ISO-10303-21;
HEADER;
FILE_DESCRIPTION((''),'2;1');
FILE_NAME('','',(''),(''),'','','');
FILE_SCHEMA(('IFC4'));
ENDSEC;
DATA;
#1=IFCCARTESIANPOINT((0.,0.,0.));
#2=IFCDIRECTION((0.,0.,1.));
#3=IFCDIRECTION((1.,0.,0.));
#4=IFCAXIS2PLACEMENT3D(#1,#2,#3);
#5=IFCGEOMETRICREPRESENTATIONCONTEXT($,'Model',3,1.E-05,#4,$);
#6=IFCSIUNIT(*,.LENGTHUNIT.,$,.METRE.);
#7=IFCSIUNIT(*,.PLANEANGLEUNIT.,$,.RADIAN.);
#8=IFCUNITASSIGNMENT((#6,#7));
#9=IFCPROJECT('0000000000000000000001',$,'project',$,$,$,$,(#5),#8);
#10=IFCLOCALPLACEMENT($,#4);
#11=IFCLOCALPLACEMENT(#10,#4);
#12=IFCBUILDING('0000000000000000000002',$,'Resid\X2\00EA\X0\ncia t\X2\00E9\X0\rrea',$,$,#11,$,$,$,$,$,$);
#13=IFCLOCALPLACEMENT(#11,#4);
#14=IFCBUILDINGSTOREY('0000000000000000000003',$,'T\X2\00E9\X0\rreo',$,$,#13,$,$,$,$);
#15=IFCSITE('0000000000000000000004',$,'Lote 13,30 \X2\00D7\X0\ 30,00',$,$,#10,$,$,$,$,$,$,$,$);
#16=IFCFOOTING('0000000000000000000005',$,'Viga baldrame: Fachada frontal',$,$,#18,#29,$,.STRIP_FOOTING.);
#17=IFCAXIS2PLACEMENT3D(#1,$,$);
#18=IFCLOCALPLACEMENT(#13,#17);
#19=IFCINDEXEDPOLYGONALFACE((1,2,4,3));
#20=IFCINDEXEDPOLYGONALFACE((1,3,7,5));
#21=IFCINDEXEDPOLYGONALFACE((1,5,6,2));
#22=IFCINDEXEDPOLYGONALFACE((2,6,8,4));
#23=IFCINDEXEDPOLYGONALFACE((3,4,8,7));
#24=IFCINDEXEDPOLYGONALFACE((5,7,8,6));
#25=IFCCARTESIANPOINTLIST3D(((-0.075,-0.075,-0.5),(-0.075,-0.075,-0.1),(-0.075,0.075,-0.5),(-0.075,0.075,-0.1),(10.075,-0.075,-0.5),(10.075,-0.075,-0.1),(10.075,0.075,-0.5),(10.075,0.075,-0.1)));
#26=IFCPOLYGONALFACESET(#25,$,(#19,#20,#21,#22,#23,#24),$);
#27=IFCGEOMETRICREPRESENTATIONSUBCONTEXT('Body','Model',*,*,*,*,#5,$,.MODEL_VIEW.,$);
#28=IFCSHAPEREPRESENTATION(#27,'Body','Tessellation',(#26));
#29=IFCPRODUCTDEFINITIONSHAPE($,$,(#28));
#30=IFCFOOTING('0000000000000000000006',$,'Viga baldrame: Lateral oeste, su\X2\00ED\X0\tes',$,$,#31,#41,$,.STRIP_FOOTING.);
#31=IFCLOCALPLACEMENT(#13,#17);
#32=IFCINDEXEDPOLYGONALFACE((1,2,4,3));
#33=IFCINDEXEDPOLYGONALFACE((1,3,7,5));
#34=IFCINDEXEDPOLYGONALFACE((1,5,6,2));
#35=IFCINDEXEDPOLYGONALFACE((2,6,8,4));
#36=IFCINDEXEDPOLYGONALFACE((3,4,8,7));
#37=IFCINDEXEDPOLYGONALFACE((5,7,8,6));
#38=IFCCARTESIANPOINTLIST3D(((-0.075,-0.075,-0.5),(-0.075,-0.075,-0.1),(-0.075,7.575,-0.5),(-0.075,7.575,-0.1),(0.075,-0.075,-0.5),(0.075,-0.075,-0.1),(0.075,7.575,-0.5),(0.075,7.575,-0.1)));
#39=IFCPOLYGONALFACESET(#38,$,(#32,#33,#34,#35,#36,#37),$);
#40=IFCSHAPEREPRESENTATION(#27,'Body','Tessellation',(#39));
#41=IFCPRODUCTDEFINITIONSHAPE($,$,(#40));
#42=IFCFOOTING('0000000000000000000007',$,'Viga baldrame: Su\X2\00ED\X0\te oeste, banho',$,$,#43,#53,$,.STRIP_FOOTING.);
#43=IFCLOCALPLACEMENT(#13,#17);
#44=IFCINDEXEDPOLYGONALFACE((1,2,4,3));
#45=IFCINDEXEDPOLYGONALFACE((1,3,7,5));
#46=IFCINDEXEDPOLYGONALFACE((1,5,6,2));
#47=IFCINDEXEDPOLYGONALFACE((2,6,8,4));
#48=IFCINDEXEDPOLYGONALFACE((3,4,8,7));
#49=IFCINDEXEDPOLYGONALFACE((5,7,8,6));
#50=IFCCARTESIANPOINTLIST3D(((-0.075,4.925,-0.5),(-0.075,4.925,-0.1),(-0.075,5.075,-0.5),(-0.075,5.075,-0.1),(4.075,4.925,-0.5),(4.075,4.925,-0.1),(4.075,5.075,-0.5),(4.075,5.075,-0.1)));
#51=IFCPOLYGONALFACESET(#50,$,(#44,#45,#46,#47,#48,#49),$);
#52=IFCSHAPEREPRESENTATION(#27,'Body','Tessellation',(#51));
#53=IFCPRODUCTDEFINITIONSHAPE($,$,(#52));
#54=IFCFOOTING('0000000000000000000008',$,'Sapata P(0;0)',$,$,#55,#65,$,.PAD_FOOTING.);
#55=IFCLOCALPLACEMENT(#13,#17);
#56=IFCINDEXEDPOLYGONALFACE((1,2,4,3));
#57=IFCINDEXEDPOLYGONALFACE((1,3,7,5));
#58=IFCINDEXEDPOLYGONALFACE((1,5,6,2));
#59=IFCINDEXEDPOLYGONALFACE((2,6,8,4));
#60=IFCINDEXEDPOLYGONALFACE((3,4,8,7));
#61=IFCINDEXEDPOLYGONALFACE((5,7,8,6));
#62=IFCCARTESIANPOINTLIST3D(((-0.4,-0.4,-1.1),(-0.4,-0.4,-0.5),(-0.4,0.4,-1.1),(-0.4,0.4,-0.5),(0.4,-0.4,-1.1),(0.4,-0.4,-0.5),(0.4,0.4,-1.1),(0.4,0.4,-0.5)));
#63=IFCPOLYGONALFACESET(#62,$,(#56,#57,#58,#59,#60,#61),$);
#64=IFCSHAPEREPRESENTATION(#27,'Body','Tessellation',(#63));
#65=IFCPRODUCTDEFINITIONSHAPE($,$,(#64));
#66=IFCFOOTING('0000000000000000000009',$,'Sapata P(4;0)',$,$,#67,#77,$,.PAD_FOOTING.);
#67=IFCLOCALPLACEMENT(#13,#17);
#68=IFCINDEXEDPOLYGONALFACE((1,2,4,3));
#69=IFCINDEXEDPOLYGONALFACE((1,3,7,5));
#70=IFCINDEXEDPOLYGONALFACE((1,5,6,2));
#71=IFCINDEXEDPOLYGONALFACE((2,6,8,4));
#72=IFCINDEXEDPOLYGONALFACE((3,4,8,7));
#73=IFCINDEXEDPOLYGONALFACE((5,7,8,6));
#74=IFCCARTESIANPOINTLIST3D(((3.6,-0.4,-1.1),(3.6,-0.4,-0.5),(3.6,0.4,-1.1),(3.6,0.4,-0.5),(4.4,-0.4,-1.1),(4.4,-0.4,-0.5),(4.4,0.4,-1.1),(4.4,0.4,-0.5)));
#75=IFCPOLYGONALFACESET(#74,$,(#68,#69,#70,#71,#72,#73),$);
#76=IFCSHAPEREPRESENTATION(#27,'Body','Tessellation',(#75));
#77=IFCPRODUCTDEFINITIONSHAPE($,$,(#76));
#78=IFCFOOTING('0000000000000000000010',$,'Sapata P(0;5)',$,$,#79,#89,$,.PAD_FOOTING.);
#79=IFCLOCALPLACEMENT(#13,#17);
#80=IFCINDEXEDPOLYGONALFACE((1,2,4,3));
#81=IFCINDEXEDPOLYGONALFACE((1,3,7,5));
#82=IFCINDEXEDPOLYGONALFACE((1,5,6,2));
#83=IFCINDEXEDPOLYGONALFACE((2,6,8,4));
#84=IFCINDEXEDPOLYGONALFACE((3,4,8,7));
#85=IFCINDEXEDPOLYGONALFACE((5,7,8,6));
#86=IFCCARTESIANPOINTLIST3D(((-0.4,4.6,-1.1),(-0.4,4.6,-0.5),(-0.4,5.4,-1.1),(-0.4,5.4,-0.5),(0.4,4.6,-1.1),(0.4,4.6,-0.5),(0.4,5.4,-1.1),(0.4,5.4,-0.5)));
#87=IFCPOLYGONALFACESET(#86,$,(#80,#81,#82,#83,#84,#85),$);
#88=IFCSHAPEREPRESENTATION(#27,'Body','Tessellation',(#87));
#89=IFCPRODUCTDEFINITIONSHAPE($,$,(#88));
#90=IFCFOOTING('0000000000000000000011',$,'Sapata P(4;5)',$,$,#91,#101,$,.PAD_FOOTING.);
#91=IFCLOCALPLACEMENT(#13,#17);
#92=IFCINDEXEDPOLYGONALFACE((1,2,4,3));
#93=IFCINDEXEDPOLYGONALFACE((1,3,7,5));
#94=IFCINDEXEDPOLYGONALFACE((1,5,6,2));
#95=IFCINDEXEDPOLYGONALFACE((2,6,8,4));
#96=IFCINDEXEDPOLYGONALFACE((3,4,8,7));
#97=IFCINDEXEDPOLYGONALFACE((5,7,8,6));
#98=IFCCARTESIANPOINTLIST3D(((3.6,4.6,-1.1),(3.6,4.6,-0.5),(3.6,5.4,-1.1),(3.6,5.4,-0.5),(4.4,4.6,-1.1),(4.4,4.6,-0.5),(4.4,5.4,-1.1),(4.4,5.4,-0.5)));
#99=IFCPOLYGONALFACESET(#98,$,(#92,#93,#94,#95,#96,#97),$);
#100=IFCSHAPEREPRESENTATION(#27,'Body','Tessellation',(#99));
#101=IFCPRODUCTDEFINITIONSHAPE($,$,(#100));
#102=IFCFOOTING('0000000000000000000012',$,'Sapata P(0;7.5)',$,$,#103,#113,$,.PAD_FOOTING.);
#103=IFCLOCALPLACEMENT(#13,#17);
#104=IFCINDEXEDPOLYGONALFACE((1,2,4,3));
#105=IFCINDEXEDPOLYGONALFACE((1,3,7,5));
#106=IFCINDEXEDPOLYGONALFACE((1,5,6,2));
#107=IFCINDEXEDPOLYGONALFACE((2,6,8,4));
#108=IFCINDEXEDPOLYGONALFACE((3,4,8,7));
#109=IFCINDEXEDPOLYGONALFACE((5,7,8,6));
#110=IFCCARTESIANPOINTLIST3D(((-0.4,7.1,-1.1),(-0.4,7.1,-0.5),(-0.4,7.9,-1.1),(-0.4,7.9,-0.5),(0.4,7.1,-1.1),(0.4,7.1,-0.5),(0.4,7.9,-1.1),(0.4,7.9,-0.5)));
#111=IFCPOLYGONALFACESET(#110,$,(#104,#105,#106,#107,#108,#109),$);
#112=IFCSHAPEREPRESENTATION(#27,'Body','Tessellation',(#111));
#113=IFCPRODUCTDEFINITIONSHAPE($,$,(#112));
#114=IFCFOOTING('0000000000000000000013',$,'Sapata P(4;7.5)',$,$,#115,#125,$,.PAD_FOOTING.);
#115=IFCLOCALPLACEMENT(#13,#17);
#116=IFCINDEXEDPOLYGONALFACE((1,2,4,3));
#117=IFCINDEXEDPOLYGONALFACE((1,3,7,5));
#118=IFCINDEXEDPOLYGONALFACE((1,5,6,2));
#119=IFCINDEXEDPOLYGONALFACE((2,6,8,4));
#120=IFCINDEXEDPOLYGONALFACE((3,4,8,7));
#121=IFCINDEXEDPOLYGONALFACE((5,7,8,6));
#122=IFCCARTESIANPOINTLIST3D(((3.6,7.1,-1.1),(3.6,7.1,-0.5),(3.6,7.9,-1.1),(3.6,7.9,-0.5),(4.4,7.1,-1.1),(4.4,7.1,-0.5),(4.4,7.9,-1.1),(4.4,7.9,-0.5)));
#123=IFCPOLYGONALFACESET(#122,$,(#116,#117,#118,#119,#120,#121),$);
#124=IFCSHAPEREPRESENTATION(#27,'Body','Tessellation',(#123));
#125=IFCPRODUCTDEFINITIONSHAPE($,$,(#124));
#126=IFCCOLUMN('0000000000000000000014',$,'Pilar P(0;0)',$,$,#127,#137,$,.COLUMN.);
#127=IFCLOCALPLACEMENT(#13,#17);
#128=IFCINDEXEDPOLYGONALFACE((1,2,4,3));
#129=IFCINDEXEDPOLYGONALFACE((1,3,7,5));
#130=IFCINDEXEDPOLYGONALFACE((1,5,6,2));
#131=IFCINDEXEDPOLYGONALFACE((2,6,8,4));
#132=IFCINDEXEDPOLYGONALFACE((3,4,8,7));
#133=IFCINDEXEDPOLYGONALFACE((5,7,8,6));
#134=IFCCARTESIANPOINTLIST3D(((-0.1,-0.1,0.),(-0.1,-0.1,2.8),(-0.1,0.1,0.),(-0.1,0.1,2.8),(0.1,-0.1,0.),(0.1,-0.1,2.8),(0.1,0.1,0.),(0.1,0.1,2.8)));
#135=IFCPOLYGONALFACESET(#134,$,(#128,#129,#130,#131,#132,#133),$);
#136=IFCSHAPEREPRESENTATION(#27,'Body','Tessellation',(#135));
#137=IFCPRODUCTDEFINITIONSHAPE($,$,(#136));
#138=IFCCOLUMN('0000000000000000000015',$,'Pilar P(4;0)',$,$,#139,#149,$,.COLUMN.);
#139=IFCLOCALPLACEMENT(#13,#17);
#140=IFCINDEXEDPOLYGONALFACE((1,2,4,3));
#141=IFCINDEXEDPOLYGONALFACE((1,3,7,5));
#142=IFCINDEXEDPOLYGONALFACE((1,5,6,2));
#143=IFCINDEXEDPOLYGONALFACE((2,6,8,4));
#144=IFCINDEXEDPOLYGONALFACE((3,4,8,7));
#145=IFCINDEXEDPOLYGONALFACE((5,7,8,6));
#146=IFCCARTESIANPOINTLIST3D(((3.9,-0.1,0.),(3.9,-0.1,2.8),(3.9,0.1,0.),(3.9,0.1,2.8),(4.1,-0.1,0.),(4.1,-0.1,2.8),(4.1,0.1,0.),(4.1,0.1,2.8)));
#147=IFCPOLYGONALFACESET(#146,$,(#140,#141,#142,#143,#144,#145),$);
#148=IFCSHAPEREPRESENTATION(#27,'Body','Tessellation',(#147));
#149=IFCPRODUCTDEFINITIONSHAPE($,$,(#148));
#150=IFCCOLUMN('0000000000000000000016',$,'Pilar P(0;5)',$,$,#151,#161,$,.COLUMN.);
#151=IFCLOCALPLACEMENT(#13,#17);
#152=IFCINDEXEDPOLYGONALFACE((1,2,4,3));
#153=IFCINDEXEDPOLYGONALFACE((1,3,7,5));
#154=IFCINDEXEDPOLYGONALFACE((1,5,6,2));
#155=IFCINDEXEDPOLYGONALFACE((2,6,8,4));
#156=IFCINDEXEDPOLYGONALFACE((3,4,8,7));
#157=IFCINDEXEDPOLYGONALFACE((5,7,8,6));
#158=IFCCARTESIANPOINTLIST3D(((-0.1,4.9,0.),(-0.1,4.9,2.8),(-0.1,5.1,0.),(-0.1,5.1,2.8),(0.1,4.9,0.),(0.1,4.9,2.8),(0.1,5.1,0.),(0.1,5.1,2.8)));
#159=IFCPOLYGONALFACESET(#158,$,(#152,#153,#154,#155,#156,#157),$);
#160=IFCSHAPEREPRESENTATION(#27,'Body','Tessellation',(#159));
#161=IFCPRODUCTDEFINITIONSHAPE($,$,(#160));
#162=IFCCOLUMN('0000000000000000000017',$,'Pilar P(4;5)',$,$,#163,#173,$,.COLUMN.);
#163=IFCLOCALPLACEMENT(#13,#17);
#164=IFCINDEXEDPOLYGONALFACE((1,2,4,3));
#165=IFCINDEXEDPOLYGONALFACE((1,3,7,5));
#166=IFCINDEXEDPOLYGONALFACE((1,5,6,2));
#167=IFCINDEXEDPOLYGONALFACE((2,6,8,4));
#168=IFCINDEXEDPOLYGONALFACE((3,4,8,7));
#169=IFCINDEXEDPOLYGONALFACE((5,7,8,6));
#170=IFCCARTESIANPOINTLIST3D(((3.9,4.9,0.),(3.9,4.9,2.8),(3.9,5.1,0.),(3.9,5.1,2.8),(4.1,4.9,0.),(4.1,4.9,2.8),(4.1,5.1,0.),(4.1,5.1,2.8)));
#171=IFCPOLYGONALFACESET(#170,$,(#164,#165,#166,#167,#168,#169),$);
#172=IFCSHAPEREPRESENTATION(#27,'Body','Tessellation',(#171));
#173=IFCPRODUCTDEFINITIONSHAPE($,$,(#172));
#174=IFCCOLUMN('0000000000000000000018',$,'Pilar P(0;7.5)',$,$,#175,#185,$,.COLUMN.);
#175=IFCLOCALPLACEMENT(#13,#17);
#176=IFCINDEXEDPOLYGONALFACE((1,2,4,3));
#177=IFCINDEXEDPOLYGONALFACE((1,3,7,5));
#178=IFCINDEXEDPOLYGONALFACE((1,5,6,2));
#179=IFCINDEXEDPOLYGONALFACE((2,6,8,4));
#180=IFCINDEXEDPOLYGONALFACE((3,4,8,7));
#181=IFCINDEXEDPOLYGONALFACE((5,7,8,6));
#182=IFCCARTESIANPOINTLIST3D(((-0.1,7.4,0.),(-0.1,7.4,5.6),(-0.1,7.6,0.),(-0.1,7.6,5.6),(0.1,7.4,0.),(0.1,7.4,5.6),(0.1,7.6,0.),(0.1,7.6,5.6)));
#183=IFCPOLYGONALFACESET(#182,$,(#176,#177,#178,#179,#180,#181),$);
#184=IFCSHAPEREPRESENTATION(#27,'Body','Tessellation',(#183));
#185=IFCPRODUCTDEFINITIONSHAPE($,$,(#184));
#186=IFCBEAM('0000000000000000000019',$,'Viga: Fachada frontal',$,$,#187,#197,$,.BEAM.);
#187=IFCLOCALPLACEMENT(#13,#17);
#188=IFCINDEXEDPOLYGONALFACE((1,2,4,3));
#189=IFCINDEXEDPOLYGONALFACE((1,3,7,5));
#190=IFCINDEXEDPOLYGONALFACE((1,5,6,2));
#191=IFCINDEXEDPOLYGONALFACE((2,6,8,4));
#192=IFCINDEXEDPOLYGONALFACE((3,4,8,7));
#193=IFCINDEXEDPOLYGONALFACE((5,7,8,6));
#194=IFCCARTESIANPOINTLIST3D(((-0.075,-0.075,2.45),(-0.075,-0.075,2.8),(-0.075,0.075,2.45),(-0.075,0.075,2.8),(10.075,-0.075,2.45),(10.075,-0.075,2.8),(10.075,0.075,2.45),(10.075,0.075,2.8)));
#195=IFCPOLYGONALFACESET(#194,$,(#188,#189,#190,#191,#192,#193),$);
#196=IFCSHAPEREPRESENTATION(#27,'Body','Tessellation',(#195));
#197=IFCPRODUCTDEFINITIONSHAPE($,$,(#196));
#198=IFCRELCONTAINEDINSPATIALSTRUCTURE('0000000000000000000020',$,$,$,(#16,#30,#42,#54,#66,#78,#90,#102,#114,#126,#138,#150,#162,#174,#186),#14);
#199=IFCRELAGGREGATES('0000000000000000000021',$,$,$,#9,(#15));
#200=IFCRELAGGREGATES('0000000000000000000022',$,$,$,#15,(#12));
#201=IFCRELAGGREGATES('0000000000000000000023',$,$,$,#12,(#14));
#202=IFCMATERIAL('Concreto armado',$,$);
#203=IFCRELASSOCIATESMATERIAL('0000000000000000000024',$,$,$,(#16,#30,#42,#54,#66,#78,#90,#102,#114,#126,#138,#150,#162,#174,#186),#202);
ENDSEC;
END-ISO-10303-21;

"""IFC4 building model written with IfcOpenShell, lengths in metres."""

from ifc_helpers import new_model, si_unit, frame, origin_with_axes, place, context, subcontext, project, spatial, line, indexed_curve, outline, extrude, material, element, save


model = new_model("IFC4")

# Units and contexts
model_context = context("Model", 3, precision=1e-05, world=origin_with_axes())
body_context = subcontext(model_context, "Body", "Model", "MODEL_VIEW")
ifc_project = project(units=[si_unit("LENGTHUNIT", "METRE"), si_unit("PLANEANGLEUNIT", "RADIAN")], contexts=[model_context])

# Site, building, storey
site_placement = place(None, origin_with_axes())
site = spatial("IfcSite", under=ifc_project, at=site_placement, Name="Lote 13,30 × 30,00")
building_placement = place(site_placement, origin_with_axes())
building = spatial("IfcBuilding", under=site, at=building_placement, Name="Residência térrea")
storey_placement = place(building_placement, origin_with_axes())
storey = spatial("IfcBuildingStorey", under=building, at=storey_placement, Name="Térreo")

# Footings
ifc_material_1 = material(Name="Concreto armado")
footing_1_placement = place(storey_placement, frame((-0.075, -0.075, -0.5), z_axis=(0.0, 0.0, 1.0), x_axis=(1.0, 0.0, 0.0)))
element("IfcFooting", 1, at=footing_1_placement, inside=storey, material=ifc_material_1, Name="Viga baldrame: Fachada frontal", PredefinedType="STRIP_FOOTING", context=body_context, shape_type="SweptSolid", body=[
    extrude(outline(indexed_curve([(0.0, 0.0), (10.15, 0.0), (10.15, 0.15), (0.0, 0.15)], segments=[line(1, 2, 3, 4, 1)])), origin_with_axes(), (0.0, 0.0, 1.0), 0.4),
])
footing_2_placement = place(storey_placement, frame((-0.075, -0.075, -0.5), z_axis=(0.0, 0.0, 1.0), x_axis=(1.0, 0.0, 0.0)))
element("IfcFooting", 2, at=footing_2_placement, inside=storey, material=ifc_material_1, Name="Viga baldrame: Lateral oeste, suítes", PredefinedType="STRIP_FOOTING", context=body_context, shape_type="SweptSolid", body=[
    extrude(outline(indexed_curve([(0.0, 0.0), (0.15, 0.0), (0.15, 7.65), (0.0, 7.65)], segments=[line(1, 2, 3, 4, 1)])), origin_with_axes(), (0.0, 0.0, 1.0), 0.4),
])
footing_3_placement = place(storey_placement, frame((-0.075, 4.925, -0.5), z_axis=(0.0, 0.0, 1.0), x_axis=(1.0, 0.0, 0.0)))
element("IfcFooting", 3, at=footing_3_placement, inside=storey, material=ifc_material_1, Name="Viga baldrame: Suíte oeste, banho", PredefinedType="STRIP_FOOTING", context=body_context, shape_type="SweptSolid", body=[
    extrude(outline(indexed_curve([(0.0, 0.0), (4.15, 0.0), (4.15, 0.15), (0.0, 0.15)], segments=[line(1, 2, 3, 4, 1)])), origin_with_axes(), (0.0, 0.0, 1.0), 0.4),
])
footing_4_placement = place(storey_placement, frame((-0.4, -0.4, -1.1), z_axis=(0.0, 0.0, 1.0), x_axis=(1.0, 0.0, 0.0)))
element("IfcFooting", 4, at=footing_4_placement, inside=storey, material=ifc_material_1, Name="Sapata P(0;0)", PredefinedType="PAD_FOOTING", context=body_context, shape_type="SweptSolid", body=[
    extrude(outline(indexed_curve([(0.0, 0.0), (0.8, 0.0), (0.8, 0.8), (0.0, 0.8)], segments=[line(1, 2, 3, 4, 1)])), origin_with_axes(), (0.0, 0.0, 1.0), 0.6),
])
footing_5_placement = place(storey_placement, frame((3.6, -0.4, -1.1), z_axis=(0.0, 0.0, 1.0), x_axis=(1.0, 0.0, 0.0)))
element("IfcFooting", 5, at=footing_5_placement, inside=storey, material=ifc_material_1, Name="Sapata P(4;0)", PredefinedType="PAD_FOOTING", context=body_context, shape_type="SweptSolid", body=[
    extrude(outline(indexed_curve([(0.0, 0.0), (0.8, 0.0), (0.8, 0.8), (0.0, 0.8)], segments=[line(1, 2, 3, 4, 1)])), origin_with_axes(), (0.0, 0.0, 1.0), 0.6),
])
footing_6_placement = place(storey_placement, frame((-0.4, 4.6, -1.1), z_axis=(0.0, 0.0, 1.0), x_axis=(1.0, 0.0, 0.0)))
element("IfcFooting", 6, at=footing_6_placement, inside=storey, material=ifc_material_1, Name="Sapata P(0;5)", PredefinedType="PAD_FOOTING", context=body_context, shape_type="SweptSolid", body=[
    extrude(outline(indexed_curve([(0.0, 0.0), (0.8, 0.0), (0.8, 0.8), (0.0, 0.8)], segments=[line(1, 2, 3, 4, 1)])), origin_with_axes(), (0.0, 0.0, 1.0), 0.6),
])
footing_7_placement = place(storey_placement, frame((3.6, 4.6, -1.1), z_axis=(0.0, 0.0, 1.0), x_axis=(1.0, 0.0, 0.0)))
element("IfcFooting", 7, at=footing_7_placement, inside=storey, material=ifc_material_1, Name="Sapata P(4;5)", PredefinedType="PAD_FOOTING", context=body_context, shape_type="SweptSolid", body=[
    extrude(outline(indexed_curve([(0.0, 0.0), (0.8, 0.0), (0.8, 0.8), (0.0, 0.8)], segments=[line(1, 2, 3, 4, 1)])), origin_with_axes(), (0.0, 0.0, 1.0), 0.6),
])
footing_8_placement = place(storey_placement, frame((-0.4, 7.1, -1.1), z_axis=(0.0, 0.0, 1.0), x_axis=(1.0, 0.0, 0.0)))
element("IfcFooting", 8, at=footing_8_placement, inside=storey, material=ifc_material_1, Name="Sapata P(0;7.5)", PredefinedType="PAD_FOOTING", context=body_context, shape_type="SweptSolid", body=[
    extrude(outline(indexed_curve([(0.0, 0.0), (0.8, 0.0), (0.8, 0.8), (0.0, 0.8)], segments=[line(1, 2, 3, 4, 1)])), origin_with_axes(), (0.0, 0.0, 1.0), 0.6),
])
footing_9_placement = place(storey_placement, frame((3.6, 7.1, -1.1), z_axis=(0.0, 0.0, 1.0), x_axis=(1.0, 0.0, 0.0)))
element("IfcFooting", 9, at=footing_9_placement, inside=storey, material=ifc_material_1, Name="Sapata P(4;7.5)", PredefinedType="PAD_FOOTING", context=body_context, shape_type="SweptSolid", body=[
    extrude(outline(indexed_curve([(0.0, 0.0), (0.8, 0.0), (0.8, 0.8), (0.0, 0.8)], segments=[line(1, 2, 3, 4, 1)])), origin_with_axes(), (0.0, 0.0, 1.0), 0.6),
])

# Columns
column_1_placement = place(storey_placement, frame((-0.1, -0.1, 0.0), z_axis=(0.0, 0.0, 1.0), x_axis=(1.0, 0.0, 0.0)))
element("IfcColumn", 10, at=column_1_placement, inside=storey, material=ifc_material_1, Name="Pilar P(0;0)", PredefinedType="COLUMN", context=body_context, shape_type="SweptSolid", body=[
    extrude(outline(indexed_curve([(0.0, 0.0), (0.2, 0.0), (0.2, 0.2), (0.0, 0.2)], segments=[line(1, 2, 3, 4, 1)])), origin_with_axes(), (0.0, 0.0, 1.0), 2.8),
])
column_2_placement = place(storey_placement, frame((3.9, -0.1, 0.0), z_axis=(0.0, 0.0, 1.0), x_axis=(1.0, 0.0, 0.0)))
element("IfcColumn", 11, at=column_2_placement, inside=storey, material=ifc_material_1, Name="Pilar P(4;0)", PredefinedType="COLUMN", context=body_context, shape_type="SweptSolid", body=[
    extrude(outline(indexed_curve([(0.0, 0.0), (0.2, 0.0), (0.2, 0.2), (0.0, 0.2)], segments=[line(1, 2, 3, 4, 1)])), origin_with_axes(), (0.0, 0.0, 1.0), 2.8),
])
column_3_placement = place(storey_placement, frame((-0.1, 4.9, 0.0), z_axis=(0.0, 0.0, 1.0), x_axis=(1.0, 0.0, 0.0)))
element("IfcColumn", 12, at=column_3_placement, inside=storey, material=ifc_material_1, Name="Pilar P(0;5)", PredefinedType="COLUMN", context=body_context, shape_type="SweptSolid", body=[
    extrude(outline(indexed_curve([(0.0, 0.0), (0.2, 0.0), (0.2, 0.2), (0.0, 0.2)], segments=[line(1, 2, 3, 4, 1)])), origin_with_axes(), (0.0, 0.0, 1.0), 2.8),
])
column_4_placement = place(storey_placement, frame((3.9, 4.9, 0.0), z_axis=(0.0, 0.0, 1.0), x_axis=(1.0, 0.0, 0.0)))
element("IfcColumn", 13, at=column_4_placement, inside=storey, material=ifc_material_1, Name="Pilar P(4;5)", PredefinedType="COLUMN", context=body_context, shape_type="SweptSolid", body=[
    extrude(outline(indexed_curve([(0.0, 0.0), (0.2, 0.0), (0.2, 0.2), (0.0, 0.2)], segments=[line(1, 2, 3, 4, 1)])), origin_with_axes(), (0.0, 0.0, 1.0), 2.8),
])
column_5_placement = place(storey_placement, frame((-0.1, 7.4, 0.0), z_axis=(0.0, 0.0, 1.0), x_axis=(1.0, 0.0, 0.0)))
element("IfcColumn", 14, at=column_5_placement, inside=storey, material=ifc_material_1, Name="Pilar P(0;7.5)", PredefinedType="COLUMN", context=body_context, shape_type="SweptSolid", body=[
    extrude(outline(indexed_curve([(0.0, 0.0), (0.2, 0.0), (0.2, 0.2), (0.0, 0.2)], segments=[line(1, 2, 3, 4, 1)])), origin_with_axes(), (0.0, 0.0, 1.0), 5.6),
])

# Beam
beam_1_placement = place(storey_placement, frame((-0.075, -0.075, 2.45), z_axis=(0.0, 0.0, 1.0), x_axis=(1.0, 0.0, 0.0)))
element("IfcBeam", 15, at=beam_1_placement, inside=storey, material=ifc_material_1, Name="Viga: Fachada frontal", PredefinedType="BEAM", context=body_context, shape_type="SweptSolid", body=[
    extrude(outline(indexed_curve([(0.0, 0.0), (10.15, 0.0), (10.15, 0.15), (0.0, 0.15)], segments=[line(1, 2, 3, 4, 1)])), origin_with_axes(), (0.0, 0.0, 1.0), 0.35),
])

save(model, "model.ifc")
